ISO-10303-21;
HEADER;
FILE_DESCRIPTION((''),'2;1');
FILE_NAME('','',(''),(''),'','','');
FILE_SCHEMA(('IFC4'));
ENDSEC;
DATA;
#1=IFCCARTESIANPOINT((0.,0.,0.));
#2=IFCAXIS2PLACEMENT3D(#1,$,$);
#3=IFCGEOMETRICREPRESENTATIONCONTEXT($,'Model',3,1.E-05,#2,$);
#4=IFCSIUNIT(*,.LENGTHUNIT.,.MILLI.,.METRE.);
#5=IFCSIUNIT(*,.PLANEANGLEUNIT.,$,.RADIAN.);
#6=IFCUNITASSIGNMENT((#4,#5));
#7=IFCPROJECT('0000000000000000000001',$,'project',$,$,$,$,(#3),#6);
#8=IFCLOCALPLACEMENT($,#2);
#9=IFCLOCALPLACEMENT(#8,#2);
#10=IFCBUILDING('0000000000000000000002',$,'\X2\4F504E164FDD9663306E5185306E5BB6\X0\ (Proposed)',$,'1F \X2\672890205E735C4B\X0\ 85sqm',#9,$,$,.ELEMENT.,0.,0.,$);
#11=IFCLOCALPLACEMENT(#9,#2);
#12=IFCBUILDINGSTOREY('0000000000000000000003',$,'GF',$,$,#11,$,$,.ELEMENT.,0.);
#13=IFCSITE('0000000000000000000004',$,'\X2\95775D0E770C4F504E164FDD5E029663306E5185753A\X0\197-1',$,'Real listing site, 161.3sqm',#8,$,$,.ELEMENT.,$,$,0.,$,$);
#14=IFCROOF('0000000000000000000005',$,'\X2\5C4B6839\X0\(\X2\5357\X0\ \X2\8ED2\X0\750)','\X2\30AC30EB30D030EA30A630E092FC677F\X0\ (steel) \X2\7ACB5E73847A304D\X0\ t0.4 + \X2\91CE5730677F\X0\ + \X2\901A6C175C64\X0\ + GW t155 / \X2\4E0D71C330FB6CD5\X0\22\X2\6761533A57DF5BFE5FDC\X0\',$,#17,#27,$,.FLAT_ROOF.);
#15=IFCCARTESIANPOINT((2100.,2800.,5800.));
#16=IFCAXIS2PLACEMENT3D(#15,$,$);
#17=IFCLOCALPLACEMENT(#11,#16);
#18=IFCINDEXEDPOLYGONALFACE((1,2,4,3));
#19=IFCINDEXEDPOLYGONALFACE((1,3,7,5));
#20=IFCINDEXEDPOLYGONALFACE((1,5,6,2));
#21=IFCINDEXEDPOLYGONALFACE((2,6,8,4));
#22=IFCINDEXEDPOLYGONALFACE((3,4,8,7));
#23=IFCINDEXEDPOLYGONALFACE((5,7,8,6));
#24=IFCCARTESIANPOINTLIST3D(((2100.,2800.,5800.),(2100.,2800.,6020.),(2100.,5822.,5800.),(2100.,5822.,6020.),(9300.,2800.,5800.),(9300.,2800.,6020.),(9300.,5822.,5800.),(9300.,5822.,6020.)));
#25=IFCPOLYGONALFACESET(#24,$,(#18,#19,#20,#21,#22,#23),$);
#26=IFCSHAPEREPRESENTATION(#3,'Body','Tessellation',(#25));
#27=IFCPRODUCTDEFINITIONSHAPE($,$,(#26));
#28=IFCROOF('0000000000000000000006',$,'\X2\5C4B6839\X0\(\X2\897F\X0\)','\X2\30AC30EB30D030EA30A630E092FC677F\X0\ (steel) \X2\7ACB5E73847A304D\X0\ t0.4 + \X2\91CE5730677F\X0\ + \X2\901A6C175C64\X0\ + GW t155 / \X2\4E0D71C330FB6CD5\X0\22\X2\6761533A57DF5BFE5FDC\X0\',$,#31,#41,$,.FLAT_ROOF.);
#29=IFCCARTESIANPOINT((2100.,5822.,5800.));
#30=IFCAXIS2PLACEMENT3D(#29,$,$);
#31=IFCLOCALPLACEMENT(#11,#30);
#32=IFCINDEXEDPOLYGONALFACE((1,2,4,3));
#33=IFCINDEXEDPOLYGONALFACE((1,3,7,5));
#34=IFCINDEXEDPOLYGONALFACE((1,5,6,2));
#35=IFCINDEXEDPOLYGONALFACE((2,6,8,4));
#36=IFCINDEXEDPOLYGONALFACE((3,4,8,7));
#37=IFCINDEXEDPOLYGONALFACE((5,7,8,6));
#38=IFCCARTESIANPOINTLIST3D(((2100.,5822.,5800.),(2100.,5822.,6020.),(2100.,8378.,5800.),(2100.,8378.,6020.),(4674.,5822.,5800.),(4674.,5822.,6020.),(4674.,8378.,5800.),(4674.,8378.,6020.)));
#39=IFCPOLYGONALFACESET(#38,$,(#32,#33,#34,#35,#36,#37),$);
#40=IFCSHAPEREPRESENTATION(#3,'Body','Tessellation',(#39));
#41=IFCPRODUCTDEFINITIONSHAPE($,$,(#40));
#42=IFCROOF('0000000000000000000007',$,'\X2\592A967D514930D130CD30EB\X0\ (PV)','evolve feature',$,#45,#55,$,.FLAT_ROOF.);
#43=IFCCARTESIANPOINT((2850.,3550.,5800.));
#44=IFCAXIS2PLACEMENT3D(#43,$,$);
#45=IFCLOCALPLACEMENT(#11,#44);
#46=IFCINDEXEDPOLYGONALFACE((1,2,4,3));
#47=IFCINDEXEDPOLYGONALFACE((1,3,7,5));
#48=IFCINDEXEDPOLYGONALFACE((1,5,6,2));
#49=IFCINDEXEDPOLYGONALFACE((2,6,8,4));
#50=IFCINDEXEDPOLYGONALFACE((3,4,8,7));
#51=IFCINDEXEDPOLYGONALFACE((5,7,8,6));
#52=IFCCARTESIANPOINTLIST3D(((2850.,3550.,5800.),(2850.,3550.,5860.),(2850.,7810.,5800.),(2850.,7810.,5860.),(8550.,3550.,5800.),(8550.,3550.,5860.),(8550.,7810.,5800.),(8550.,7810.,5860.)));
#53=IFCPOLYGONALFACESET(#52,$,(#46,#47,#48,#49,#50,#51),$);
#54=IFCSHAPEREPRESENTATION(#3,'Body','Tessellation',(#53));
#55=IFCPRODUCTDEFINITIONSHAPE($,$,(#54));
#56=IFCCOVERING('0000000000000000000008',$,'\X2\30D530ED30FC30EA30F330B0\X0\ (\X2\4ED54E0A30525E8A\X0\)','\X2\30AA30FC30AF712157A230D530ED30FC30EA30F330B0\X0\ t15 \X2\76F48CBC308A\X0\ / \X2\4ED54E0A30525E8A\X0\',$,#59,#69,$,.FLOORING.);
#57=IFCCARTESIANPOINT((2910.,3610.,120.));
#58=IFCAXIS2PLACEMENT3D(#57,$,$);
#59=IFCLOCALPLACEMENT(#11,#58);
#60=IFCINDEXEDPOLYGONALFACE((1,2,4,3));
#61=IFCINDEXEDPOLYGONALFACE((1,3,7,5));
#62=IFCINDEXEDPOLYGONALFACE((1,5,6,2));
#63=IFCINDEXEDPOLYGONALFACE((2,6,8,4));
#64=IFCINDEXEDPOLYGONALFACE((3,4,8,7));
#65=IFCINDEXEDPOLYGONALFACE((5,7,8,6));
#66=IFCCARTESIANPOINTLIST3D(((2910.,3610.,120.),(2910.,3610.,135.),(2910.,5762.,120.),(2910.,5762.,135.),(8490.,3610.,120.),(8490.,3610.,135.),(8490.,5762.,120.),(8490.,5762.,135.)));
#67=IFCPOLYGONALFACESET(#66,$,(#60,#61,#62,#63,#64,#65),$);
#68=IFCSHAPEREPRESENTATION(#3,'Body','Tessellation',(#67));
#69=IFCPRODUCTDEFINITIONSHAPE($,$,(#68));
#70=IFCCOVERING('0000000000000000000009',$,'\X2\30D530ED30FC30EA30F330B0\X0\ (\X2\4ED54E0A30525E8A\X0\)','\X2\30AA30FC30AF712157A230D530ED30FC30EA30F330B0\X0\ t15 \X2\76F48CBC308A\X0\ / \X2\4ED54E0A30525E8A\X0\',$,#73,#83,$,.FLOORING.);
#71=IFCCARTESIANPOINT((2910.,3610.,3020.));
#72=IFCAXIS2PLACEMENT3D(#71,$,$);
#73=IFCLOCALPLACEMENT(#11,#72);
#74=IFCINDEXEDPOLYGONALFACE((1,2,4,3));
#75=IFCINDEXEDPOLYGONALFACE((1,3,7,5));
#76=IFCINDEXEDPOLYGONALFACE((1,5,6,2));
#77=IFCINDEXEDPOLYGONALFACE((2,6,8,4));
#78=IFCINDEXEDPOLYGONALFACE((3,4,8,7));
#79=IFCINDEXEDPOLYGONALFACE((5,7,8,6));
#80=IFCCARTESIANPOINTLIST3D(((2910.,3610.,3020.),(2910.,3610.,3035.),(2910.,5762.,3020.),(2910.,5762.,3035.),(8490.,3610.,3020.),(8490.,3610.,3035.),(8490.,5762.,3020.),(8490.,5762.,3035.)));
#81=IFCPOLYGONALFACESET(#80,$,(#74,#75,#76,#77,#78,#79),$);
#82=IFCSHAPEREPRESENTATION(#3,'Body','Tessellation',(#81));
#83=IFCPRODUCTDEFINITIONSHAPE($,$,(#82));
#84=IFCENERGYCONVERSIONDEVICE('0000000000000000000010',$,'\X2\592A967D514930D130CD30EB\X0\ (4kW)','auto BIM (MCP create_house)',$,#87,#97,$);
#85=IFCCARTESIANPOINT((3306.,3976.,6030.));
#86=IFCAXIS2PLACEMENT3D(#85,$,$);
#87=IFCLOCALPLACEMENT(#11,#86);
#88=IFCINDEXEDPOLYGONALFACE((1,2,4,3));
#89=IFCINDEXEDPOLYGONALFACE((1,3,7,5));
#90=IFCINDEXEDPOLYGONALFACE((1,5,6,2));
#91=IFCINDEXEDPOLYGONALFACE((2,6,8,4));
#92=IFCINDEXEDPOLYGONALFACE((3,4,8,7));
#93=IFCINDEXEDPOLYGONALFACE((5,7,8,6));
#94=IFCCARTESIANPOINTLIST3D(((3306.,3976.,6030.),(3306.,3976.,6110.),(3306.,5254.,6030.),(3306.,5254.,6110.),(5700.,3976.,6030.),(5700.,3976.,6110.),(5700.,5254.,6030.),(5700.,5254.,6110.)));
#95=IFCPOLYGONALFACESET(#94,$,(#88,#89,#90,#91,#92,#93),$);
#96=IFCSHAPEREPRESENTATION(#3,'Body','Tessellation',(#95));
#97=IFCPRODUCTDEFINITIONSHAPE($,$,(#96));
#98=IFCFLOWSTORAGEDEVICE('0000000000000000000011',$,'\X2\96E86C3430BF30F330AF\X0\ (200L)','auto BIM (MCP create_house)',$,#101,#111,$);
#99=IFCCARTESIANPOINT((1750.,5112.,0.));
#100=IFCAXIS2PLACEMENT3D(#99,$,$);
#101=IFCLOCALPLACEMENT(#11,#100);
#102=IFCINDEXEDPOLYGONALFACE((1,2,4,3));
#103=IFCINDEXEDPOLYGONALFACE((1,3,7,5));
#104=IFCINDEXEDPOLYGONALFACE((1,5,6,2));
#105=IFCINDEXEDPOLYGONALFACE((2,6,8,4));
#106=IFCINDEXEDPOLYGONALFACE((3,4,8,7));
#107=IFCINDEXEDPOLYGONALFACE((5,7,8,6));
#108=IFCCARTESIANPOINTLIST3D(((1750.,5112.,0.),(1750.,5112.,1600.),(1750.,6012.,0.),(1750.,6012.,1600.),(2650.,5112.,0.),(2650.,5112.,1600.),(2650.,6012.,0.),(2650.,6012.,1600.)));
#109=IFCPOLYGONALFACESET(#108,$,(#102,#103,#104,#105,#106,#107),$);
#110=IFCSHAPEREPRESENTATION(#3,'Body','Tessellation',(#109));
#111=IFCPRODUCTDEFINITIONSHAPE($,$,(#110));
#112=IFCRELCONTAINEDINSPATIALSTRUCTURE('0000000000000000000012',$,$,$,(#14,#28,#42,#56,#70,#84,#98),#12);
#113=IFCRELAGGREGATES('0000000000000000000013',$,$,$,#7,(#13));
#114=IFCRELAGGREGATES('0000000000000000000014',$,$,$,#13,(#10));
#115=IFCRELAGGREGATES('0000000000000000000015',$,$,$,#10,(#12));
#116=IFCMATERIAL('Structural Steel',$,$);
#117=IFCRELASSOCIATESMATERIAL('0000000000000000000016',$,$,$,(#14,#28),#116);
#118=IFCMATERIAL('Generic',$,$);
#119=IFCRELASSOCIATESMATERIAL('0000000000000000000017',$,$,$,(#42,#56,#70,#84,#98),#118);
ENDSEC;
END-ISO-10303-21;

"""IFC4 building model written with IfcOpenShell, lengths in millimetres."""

from ifc_helpers import new_model, si_unit, frame, frame_2d, origin, place, context, project, spatial, rectangle, extrude, material, element, save


model = new_model("IFC4")

# Units and contexts
model_context = context("Model", 3, precision=1e-05, world=origin())
ifc_project = project(units=[si_unit("LENGTHUNIT", "METRE", prefix="MILLI"), si_unit("PLANEANGLEUNIT", "RADIAN")], contexts=[model_context])

# Site, building, storey
site_placement = place(None, origin())
site = spatial("IfcSite", under=ifc_project, at=site_placement, Name="長崎県佐世保市陣の内町197-1", ObjectType="Real listing site, 161.3sqm", CompositionType="ELEMENT", RefElevation=0.0)
building_placement = place(site_placement, origin())
building = spatial("IfcBuilding", under=site, at=building_placement, Name="佐世保陣の内の家 (Proposed)", ObjectType="1F 木造平屋 85sqm", CompositionType="ELEMENT", ElevationOfRefHeight=0.0, ElevationOfTerrain=0.0)
storey_placement = place(building_placement, origin())
storey = spatial("IfcBuildingStorey", under=building, at=storey_placement, Name="GF", CompositionType="ELEMENT", Elevation=0.0)

# Shared definitions
ifc_material_1 = material(Name="Generic")

# Roofs
ifc_material_2 = material(Name="Structural Steel")
roof_1_placement = place(storey_placement, frame((2100.0, 2800.0, 5800.0)))
element("IfcRoof", 1, at=roof_1_placement, inside=storey, material=ifc_material_2, Name="屋根(南 軒750)", Description="ガルバリウム鋼板 (steel) 立平葺き t0.4 + 野地板 + 通気層 + GW t155 / 不燃・法22条区域対応", PredefinedType="FLAT_ROOF", context=model_context, shape_type="SweptSolid", body=[
    extrude(rectangle(XDim=7200.0, YDim=3022.0, at=frame_2d((3600.0, 1511.0))), frame((2100.0, 2800.0, 5800.0)), (0.0, 0.0, 1.0), 220.0),
])
roof_2_placement = place(storey_placement, frame((2100.0, 5822.0, 5800.0)))
element("IfcRoof", 2, at=roof_2_placement, inside=storey, material=ifc_material_2, Name="屋根(西)", Description="ガルバリウム鋼板 (steel) 立平葺き t0.4 + 野地板 + 通気層 + GW t155 / 不燃・法22条区域対応", PredefinedType="FLAT_ROOF", context=model_context, shape_type="SweptSolid", body=[
    extrude(rectangle(XDim=2574.0, YDim=2556.0, at=frame_2d((1287.0, 1278.0))), frame((2100.0, 5822.0, 5800.0)), (0.0, 0.0, 1.0), 220.0),
])
roof_3_placement = place(storey_placement, frame((2850.0, 3550.0, 5800.0)))
element("IfcRoof", 3, at=roof_3_placement, inside=storey, material=ifc_material_1, Name="太陽光パネル (PV)", Description="evolve feature", PredefinedType="FLAT_ROOF", context=model_context, shape_type="SweptSolid", body=[
    extrude(rectangle(XDim=5700.0, YDim=4260.0, at=frame_2d((2850.0, 2130.0))), frame((2850.0, 3550.0, 5800.0)), (0.0, 0.0, 1.0), 60.0),
])

# Coverings
covering_1_placement = place(storey_placement, frame((2910.0, 3610.0, 120.0)))
element("IfcCovering", 4, at=covering_1_placement, inside=storey, material=ifc_material_1, Name="フローリング (仕上げ床)", Description="オーク無垢フローリング t15 直貼り / 仕上げ床", PredefinedType="FLOORING", context=model_context, shape_type="SweptSolid", body=[
    extrude(rectangle(XDim=5580.0, YDim=2152.0, at=frame_2d((2790.0, 1076.0))), frame((2910.0, 3610.0, 120.0)), (0.0, 0.0, 1.0), 15.0),
])
covering_2_placement = place(storey_placement, frame((2910.0, 3610.0, 3020.0)))
element("IfcCovering", 5, at=covering_2_placement, inside=storey, material=ifc_material_1, Name="フローリング (仕上げ床)", Description="オーク無垢フローリング t15 直貼り / 仕上げ床", PredefinedType="FLOORING", context=model_context, shape_type="SweptSolid", body=[
    extrude(rectangle(XDim=5580.0, YDim=2152.0, at=frame_2d((2790.0, 1076.0))), frame((2910.0, 3610.0, 3020.0)), (0.0, 0.0, 1.0), 15.0),
])

# Energy conversion device
energy_conversion_device_placement = place(storey_placement, frame((3306.0, 3976.0, 6030.0)))
element("IfcEnergyConversionDevice", 6, at=energy_conversion_device_placement, inside=storey, material=ifc_material_1, Name="太陽光パネル (4kW)", Description="auto BIM (MCP create_house)", context=model_context, shape_type="SweptSolid", body=[
    extrude(rectangle(XDim=2394.0, YDim=1278.0, at=frame_2d((1197.0, 639.0))), frame((3306.0, 3976.0, 6030.0)), (0.0, 0.0, 1.0), 80.0),
])

# Flow storage device
flow_storage_device_placement = place(storey_placement, frame((1750.0, 5112.0, 0.0)))
element("IfcFlowStorageDevice", 7, at=flow_storage_device_placement, inside=storey, material=ifc_material_1, Name="雨水タンク (200L)", Description="auto BIM (MCP create_house)", context=model_context, shape_type="SweptSolid", body=[
    extrude(rectangle(XDim=900.0, YDim=900.0, at=frame_2d((450.0, 450.0))), frame((1750.0, 5112.0, 0.0)), (0.0, 0.0, 1.0), 1600.0),
])

save(model, "model.ifc")
